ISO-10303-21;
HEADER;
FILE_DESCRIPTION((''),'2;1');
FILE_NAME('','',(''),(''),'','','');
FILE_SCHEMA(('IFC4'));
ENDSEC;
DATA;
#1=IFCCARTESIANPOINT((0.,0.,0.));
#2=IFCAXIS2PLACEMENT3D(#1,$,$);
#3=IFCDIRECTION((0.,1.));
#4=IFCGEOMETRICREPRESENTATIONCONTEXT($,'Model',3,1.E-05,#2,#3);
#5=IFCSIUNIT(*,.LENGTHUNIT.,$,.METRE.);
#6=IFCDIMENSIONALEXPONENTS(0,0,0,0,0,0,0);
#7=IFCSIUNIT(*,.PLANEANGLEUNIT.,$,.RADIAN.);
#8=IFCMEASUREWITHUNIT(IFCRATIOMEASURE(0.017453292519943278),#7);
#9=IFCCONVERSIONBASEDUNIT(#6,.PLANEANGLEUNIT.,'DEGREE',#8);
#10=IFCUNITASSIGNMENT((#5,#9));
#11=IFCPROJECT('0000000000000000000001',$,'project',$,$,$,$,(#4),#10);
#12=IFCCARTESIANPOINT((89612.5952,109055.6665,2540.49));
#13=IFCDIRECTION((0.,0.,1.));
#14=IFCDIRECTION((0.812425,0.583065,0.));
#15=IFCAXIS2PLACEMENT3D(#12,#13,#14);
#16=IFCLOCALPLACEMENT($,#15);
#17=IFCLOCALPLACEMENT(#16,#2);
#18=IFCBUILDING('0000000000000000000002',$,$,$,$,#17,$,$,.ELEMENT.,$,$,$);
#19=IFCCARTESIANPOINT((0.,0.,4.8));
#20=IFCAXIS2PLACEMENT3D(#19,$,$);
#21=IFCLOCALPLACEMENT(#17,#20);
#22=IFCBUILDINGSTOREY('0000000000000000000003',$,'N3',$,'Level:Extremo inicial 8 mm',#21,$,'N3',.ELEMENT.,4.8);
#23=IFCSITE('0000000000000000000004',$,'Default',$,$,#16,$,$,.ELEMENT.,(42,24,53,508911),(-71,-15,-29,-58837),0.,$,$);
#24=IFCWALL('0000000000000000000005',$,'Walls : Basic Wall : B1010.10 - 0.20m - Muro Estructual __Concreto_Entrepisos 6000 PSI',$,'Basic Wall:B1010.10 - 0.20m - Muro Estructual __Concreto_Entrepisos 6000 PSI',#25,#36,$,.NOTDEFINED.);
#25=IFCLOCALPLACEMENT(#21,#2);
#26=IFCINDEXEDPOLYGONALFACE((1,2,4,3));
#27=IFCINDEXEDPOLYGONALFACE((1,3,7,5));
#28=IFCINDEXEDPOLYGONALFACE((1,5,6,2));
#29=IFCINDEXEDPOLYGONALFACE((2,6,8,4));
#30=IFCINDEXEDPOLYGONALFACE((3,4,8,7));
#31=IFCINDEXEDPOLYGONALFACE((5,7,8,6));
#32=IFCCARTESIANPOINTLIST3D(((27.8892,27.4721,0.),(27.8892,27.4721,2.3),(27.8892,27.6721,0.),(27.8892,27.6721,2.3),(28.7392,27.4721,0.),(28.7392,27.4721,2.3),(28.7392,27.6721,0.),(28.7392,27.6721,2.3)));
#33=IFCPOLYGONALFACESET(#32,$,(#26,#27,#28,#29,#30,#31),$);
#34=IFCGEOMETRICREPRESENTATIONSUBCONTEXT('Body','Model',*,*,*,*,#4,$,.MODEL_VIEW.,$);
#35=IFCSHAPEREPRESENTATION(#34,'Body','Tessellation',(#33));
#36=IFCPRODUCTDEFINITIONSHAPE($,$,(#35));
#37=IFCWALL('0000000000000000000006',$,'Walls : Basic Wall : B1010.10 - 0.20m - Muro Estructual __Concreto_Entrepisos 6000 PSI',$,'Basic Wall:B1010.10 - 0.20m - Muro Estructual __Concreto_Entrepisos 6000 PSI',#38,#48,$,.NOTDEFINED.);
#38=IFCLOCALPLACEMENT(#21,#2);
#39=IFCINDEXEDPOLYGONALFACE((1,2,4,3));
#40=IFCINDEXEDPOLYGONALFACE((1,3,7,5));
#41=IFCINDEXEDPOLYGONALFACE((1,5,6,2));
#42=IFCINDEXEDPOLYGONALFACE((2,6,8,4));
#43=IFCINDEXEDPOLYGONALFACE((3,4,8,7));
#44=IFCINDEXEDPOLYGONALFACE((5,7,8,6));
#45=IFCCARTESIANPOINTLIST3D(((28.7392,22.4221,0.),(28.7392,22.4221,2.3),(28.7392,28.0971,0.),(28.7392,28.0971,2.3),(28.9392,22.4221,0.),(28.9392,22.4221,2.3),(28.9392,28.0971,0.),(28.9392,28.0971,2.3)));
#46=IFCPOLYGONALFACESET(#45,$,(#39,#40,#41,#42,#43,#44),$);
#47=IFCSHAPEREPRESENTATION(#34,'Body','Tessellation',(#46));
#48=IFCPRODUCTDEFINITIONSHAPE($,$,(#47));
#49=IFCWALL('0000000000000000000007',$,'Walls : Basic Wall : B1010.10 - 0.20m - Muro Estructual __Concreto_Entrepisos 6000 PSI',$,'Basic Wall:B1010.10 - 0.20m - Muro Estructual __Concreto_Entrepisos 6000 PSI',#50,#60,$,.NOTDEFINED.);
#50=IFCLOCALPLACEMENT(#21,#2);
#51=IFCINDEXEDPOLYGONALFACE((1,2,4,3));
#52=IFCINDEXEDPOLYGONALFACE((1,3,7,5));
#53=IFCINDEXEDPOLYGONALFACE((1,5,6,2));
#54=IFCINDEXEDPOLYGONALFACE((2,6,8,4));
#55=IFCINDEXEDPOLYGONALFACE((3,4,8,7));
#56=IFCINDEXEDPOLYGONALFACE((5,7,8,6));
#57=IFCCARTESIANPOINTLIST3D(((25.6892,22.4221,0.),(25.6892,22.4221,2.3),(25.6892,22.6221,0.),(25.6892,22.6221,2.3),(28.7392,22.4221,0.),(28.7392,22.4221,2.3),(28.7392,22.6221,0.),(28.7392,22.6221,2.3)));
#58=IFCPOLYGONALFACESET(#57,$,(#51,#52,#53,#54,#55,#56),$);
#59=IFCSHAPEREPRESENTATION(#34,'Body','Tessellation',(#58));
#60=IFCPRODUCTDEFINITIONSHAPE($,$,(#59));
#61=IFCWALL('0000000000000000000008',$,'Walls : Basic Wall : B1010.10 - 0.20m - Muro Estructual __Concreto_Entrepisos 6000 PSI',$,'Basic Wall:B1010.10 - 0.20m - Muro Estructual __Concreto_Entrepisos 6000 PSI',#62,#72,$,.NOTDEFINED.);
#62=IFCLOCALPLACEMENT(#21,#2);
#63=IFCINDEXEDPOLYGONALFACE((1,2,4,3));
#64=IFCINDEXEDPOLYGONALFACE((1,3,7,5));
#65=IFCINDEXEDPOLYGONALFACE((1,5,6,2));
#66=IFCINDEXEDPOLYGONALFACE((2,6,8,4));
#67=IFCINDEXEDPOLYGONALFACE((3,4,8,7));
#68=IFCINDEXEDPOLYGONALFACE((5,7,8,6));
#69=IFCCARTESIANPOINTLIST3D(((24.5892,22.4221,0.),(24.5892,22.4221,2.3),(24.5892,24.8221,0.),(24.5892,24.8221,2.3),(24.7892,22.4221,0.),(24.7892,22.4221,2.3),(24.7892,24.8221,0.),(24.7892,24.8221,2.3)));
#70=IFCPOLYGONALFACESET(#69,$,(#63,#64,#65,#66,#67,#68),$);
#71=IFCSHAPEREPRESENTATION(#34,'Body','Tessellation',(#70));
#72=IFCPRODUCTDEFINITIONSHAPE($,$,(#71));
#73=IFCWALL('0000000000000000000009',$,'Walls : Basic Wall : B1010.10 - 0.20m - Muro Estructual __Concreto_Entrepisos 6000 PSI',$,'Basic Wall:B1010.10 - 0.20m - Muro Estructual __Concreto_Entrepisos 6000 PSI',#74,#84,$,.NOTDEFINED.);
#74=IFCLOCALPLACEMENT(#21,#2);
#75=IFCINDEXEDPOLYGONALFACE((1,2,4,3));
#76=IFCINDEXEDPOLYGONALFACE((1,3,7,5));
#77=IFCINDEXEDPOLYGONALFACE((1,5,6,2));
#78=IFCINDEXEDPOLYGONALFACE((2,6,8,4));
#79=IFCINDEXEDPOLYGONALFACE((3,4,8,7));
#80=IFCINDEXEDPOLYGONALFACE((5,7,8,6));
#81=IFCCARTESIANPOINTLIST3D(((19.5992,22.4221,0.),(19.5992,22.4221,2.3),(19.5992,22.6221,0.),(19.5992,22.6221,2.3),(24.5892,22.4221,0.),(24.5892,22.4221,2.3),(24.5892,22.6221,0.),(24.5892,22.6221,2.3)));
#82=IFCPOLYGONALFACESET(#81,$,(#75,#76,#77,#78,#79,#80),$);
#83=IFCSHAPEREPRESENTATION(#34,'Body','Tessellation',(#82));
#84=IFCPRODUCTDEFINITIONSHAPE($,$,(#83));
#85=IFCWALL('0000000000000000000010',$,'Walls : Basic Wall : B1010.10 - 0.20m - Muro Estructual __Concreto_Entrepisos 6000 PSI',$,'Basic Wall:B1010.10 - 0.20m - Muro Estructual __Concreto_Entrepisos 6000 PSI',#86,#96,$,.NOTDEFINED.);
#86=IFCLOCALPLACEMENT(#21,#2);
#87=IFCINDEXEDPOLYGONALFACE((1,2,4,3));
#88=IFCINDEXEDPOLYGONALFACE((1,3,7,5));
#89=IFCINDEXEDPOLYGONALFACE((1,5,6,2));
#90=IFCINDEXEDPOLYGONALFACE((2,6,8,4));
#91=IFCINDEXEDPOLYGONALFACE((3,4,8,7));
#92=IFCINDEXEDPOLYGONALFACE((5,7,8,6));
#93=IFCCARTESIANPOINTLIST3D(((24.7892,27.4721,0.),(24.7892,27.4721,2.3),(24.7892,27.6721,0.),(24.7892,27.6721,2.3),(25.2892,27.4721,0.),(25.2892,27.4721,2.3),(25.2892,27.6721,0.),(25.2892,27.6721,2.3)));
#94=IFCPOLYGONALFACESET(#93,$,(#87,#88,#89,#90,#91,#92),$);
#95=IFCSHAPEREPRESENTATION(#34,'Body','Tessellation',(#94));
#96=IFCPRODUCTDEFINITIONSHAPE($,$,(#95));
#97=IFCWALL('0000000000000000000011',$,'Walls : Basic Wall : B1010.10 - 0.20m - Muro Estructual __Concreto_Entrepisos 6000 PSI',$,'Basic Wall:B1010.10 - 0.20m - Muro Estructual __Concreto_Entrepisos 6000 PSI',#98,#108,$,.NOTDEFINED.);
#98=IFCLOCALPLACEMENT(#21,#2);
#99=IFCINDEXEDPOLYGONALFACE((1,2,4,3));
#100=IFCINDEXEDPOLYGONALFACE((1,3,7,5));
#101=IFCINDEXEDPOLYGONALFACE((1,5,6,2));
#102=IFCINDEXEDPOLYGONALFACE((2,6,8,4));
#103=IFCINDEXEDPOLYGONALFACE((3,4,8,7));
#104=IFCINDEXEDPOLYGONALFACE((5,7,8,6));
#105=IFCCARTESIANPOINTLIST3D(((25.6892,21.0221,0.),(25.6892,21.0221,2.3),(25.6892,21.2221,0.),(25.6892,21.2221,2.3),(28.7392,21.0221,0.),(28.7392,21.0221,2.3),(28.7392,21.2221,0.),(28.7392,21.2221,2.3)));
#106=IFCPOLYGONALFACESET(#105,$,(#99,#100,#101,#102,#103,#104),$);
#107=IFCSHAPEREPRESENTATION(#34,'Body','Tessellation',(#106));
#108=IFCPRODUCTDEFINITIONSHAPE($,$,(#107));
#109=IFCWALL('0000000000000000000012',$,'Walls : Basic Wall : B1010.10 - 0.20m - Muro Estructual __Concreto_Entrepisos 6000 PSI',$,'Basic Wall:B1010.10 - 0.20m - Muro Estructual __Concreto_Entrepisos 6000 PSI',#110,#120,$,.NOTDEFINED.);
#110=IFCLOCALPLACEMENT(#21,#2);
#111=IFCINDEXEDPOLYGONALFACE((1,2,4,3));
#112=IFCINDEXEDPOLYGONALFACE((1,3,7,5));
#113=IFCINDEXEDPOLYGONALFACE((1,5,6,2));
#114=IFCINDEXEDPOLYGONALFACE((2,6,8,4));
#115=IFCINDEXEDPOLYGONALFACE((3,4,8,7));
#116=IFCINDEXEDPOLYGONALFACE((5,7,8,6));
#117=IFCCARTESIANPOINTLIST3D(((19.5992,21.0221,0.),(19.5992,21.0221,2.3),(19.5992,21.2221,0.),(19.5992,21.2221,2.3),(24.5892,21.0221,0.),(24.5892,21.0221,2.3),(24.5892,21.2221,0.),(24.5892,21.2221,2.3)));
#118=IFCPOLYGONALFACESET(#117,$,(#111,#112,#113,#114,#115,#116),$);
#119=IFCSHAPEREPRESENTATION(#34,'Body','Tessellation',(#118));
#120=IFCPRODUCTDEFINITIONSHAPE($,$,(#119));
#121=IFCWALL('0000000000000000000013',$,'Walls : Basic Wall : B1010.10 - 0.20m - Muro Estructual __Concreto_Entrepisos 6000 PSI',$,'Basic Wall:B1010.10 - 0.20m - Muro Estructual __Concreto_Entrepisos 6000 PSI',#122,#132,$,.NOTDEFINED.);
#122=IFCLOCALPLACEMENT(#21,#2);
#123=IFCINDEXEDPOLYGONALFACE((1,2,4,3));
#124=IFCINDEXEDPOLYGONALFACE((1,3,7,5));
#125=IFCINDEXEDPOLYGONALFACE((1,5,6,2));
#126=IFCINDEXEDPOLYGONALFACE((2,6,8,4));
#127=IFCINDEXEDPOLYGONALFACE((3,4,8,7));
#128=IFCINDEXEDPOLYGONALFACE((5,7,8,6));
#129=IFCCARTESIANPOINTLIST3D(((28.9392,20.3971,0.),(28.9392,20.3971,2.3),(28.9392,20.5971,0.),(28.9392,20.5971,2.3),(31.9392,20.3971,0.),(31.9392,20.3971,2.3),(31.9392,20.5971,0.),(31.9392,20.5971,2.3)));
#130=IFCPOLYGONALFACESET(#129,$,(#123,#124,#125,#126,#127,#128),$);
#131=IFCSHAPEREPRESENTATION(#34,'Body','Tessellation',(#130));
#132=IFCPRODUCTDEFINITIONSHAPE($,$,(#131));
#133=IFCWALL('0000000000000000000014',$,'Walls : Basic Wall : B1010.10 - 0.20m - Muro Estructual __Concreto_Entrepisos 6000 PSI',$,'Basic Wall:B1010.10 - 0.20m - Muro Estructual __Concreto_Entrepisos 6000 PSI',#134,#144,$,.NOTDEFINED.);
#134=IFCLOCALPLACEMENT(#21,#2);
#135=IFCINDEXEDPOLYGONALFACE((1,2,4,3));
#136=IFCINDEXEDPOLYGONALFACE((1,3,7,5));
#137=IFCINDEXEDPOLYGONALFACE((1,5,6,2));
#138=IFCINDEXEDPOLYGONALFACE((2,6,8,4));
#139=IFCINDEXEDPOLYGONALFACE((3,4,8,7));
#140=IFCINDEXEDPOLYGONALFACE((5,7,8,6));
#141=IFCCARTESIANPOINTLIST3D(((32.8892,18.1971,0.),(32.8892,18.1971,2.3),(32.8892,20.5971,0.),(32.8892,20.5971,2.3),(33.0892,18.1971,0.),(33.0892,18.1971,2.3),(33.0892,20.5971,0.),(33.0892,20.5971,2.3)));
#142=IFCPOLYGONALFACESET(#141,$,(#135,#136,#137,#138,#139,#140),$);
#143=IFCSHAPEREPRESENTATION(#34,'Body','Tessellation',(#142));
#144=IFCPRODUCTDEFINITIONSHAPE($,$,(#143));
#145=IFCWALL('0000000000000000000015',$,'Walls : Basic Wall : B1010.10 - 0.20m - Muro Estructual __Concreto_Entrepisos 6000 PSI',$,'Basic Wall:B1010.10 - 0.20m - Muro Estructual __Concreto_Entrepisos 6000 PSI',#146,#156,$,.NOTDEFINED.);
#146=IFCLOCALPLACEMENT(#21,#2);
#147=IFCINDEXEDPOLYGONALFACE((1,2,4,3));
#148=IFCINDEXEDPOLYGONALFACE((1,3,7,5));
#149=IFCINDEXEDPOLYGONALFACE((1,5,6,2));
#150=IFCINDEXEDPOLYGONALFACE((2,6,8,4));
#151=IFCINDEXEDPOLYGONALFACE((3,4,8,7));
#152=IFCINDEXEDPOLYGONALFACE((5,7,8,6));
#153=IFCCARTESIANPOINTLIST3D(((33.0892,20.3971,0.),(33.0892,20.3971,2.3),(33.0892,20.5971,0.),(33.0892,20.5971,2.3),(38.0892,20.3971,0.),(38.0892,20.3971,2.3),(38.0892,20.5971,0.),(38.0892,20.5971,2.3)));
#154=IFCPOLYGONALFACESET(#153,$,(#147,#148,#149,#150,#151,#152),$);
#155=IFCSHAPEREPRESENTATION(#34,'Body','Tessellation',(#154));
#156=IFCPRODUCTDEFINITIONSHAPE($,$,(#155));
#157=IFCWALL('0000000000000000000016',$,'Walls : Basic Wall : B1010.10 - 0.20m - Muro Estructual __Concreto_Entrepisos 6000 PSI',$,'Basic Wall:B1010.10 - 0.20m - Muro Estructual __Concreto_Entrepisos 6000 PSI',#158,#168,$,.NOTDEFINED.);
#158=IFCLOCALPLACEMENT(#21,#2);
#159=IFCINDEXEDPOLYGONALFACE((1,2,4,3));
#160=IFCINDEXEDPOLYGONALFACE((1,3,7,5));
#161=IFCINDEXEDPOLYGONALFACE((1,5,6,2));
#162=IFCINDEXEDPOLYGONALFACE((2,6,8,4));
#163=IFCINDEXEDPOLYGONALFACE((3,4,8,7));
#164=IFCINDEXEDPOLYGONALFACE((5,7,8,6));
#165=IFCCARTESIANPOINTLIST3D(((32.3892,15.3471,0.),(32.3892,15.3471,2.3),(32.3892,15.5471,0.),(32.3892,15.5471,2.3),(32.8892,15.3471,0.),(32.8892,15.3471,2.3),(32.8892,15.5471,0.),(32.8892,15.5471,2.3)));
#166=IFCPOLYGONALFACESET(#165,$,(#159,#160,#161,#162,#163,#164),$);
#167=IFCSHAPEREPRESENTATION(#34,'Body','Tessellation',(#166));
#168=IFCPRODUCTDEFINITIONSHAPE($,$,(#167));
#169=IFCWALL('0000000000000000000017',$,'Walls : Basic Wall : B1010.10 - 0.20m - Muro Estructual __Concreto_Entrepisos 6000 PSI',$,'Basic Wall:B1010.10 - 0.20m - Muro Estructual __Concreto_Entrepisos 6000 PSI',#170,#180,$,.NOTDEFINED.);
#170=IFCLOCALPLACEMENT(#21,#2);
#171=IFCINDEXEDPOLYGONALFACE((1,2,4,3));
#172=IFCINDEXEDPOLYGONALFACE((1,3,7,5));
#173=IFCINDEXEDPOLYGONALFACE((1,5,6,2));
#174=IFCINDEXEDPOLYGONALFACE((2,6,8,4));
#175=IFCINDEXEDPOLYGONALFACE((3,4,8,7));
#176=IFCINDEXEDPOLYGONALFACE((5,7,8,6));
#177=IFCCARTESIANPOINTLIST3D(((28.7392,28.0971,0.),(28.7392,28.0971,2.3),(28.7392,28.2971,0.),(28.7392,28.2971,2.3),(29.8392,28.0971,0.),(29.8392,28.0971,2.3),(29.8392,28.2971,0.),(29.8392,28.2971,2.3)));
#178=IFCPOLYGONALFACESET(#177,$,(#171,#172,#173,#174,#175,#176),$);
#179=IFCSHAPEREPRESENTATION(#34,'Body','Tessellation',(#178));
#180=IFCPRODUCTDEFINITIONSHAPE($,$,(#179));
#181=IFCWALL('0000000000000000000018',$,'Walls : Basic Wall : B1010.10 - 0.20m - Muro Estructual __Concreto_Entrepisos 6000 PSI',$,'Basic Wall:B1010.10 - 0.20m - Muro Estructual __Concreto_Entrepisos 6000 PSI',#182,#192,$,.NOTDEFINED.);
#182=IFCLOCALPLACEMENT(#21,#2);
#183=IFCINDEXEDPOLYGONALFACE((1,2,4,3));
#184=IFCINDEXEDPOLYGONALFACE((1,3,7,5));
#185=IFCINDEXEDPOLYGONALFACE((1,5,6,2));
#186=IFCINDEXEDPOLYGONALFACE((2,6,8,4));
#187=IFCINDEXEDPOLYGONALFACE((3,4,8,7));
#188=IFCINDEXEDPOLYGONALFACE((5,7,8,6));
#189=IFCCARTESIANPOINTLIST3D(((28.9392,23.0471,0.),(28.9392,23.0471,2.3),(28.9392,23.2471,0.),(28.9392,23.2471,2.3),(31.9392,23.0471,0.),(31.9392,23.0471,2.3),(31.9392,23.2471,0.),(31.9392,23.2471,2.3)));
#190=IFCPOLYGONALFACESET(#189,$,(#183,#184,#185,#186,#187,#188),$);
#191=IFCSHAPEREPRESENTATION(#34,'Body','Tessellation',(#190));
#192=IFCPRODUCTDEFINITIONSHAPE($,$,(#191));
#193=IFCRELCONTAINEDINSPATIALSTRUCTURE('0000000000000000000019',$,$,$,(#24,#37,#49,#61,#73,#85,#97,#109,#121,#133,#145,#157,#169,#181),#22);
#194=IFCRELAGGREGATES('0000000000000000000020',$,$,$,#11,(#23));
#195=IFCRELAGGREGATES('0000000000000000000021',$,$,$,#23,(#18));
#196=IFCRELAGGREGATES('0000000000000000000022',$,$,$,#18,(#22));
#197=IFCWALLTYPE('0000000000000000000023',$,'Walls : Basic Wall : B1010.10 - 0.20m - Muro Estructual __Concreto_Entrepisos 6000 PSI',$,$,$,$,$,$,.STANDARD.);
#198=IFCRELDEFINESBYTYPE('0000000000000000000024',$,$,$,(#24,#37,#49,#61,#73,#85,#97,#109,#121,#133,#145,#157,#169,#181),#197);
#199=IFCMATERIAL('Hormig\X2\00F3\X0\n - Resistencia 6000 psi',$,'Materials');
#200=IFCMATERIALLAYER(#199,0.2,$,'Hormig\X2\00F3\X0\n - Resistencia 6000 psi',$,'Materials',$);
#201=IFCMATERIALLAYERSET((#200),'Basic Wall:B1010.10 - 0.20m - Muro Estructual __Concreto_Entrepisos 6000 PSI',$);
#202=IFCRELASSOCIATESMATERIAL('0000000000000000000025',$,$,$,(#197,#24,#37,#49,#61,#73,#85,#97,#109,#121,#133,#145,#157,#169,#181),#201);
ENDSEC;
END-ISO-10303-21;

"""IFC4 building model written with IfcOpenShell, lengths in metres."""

from ifc_helpers import new_model, entity, si_unit, converted_unit, direction, frame, frame_2d, origin, place, context, subcontext, project, spatial, rectangle, extrude, material, layer, layer_set, layer_usage, type_object, element, save


model = new_model("IFC4")

# Units and contexts
model_context = context("Model", 3, precision=1e-05, world=origin(), true_north=direction((0.0, 1.0)))
body_context = subcontext(model_context, "Body", "Model", "MODEL_VIEW")
ifc_project = project(units=[si_unit("LENGTHUNIT", "METRE"), converted_unit("PLANEANGLEUNIT", "DEGREE", entity("IfcRatioMeasure", 0.017453292519943278), si_unit("PLANEANGLEUNIT", "RADIAN"), dimensions=[0, 0, 0, 0, 0, 0, 0])], contexts=[model_context])

# Site, building, storey
site_placement = place(None, frame((89612.5952, 109055.6665, 2540.49), z_axis=(0.0, 0.0, 1.0), x_axis=(0.812425, 0.583065, 0.0)))
site = spatial("IfcSite", under=ifc_project, at=site_placement, Name="Default", CompositionType="ELEMENT", RefLatitude=(42, 24, 53, 508911), RefLongitude=(-71, -15, -29, -58837), RefElevation=0.0)
building_placement = place(site_placement, origin())
building = spatial("IfcBuilding", under=site, at=building_placement, CompositionType="ELEMENT")
storey_placement = place(building_placement, frame((0.0, 0.0, 4.8)))
storey = spatial("IfcBuildingStorey", under=building, at=storey_placement, Name="N3", ObjectType="Level:Extremo inicial 8 mm", LongName="N3", CompositionType="ELEMENT", Elevation=4.8)

# Walls
ifc_material = material(Name="Hormigón - Resistencia 6000 psi", Category="Materials")
ifc_layer_1 = layer(ifc_material, 0.2, Name="Hormigón - Resistencia 6000 psi", Category="Materials")
ifc_layer_set_1 = layer_set([ifc_layer_1], Name="Basic Wall:B1010.10 - 0.20m - Muro Estructual __Concreto_Entrepisos 6000 PSI")
ifc_layer_usage_1 = layer_usage(ifc_layer_set_1, "AXIS2", "NEGATIVE", 0.1)
wall_type_1 = type_object("IfcWallType", Name="Walls : Basic Wall : B1010.10 - 0.20m - Muro Estructual __Concreto_Entrepisos 6000 PSI", PredefinedType="STANDARD", material=ifc_layer_set_1)
wall_1_placement = place(storey_placement, frame((27.8892, 27.5721, 0.0)))
element("IfcWall", 1, at=wall_1_placement, inside=storey, type_object=wall_type_1, material=ifc_layer_usage_1, Name="Walls : Basic Wall : B1010.10 - 0.20m - Muro Estructual __Concreto_Entrepisos 6000 PSI", ObjectType="Basic Wall:B1010.10 - 0.20m - Muro Estructual __Concreto_Entrepisos 6000 PSI", PredefinedType="NOTDEFINED", context=body_context, shape_type="SweptSolid", body=[
    extrude(rectangle(XDim=0.85, YDim=0.2, at=frame_2d((0.425, 0.0), x_axis=(-1.0, 0.0))), origin(), (0.0, 0.0, 1.0), 2.3),
])
ifc_layer_usage_2 = layer_usage(ifc_layer_set_1, "AXIS2", "NEGATIVE", 0.1)
wall_2_placement = place(storey_placement, frame((28.8392, 28.0971, 0.0), z_axis=(0.0, 0.0, 1.0), x_axis=(0.0, -1.0, 0.0)))
element("IfcWall", 2, at=wall_2_placement, inside=storey, type_object=wall_type_1, material=ifc_layer_usage_2, Name="Walls : Basic Wall : B1010.10 - 0.20m - Muro Estructual __Concreto_Entrepisos 6000 PSI", ObjectType="Basic Wall:B1010.10 - 0.20m - Muro Estructual __Concreto_Entrepisos 6000 PSI", PredefinedType="NOTDEFINED", context=body_context, shape_type="SweptSolid", body=[
    extrude(rectangle(XDim=5.675, YDim=0.2, at=frame_2d((2.8375, 0.0), x_axis=(-1.0, 0.0))), origin(), (0.0, 0.0, 1.0), 2.3),
])
ifc_layer_usage_3 = layer_usage(ifc_layer_set_1, "AXIS2", "NEGATIVE", 0.1)
wall_3_placement = place(storey_placement, frame((28.7392, 22.5221, 0.0), z_axis=(0.0, 0.0, 1.0), x_axis=(-1.0, 0.0, 0.0)))
element("IfcWall", 3, at=wall_3_placement, inside=storey, type_object=wall_type_1, material=ifc_layer_usage_3, Name="Walls : Basic Wall : B1010.10 - 0.20m - Muro Estructual __Concreto_Entrepisos 6000 PSI", ObjectType="Basic Wall:B1010.10 - 0.20m - Muro Estructual __Concreto_Entrepisos 6000 PSI", PredefinedType="NOTDEFINED", context=body_context, shape_type="SweptSolid", body=[
    extrude(rectangle(XDim=3.05, YDim=0.2, at=frame_2d((1.525, 0.0), x_axis=(-1.0, 0.0))), origin(), (0.0, 0.0, 1.0), 2.3),
])
ifc_layer_usage_4 = layer_usage(ifc_layer_set_1, "AXIS2", "NEGATIVE", 0.1)
wall_4_placement = place(storey_placement, frame((24.6892, 24.8221, 0.0), z_axis=(0.0, 0.0, 1.0), x_axis=(0.0, -1.0, 0.0)))
element("IfcWall", 4, at=wall_4_placement, inside=storey, type_object=wall_type_1, material=ifc_layer_usage_4, Name="Walls : Basic Wall : B1010.10 - 0.20m - Muro Estructual __Concreto_Entrepisos 6000 PSI", ObjectType="Basic Wall:B1010.10 - 0.20m - Muro Estructual __Concreto_Entrepisos 6000 PSI", PredefinedType="NOTDEFINED", context=body_context, shape_type="SweptSolid", body=[
    extrude(rectangle(XDim=2.4, YDim=0.2, at=frame_2d((1.2, 0.0), x_axis=(-1.0, 0.0))), origin(), (0.0, 0.0, 1.0), 2.3),
])
ifc_layer_usage_5 = layer_usage(ifc_layer_set_1, "AXIS2", "NEGATIVE", 0.1)
wall_5_placement = place(storey_placement, frame((24.5892, 22.5221, 0.0), z_axis=(0.0, 0.0, 1.0), x_axis=(-1.0, 0.0, 0.0)))
element("IfcWall", 5, at=wall_5_placement, inside=storey, type_object=wall_type_1, material=ifc_layer_usage_5, Name="Walls : Basic Wall : B1010.10 - 0.20m - Muro Estructual __Concreto_Entrepisos 6000 PSI", ObjectType="Basic Wall:B1010.10 - 0.20m - Muro Estructual __Concreto_Entrepisos 6000 PSI", PredefinedType="NOTDEFINED", context=body_context, shape_type="SweptSolid", body=[
    extrude(rectangle(XDim=4.99, YDim=0.2, at=frame_2d((2.495, 0.0), x_axis=(-1.0, 0.0))), origin(), (0.0, 0.0, 1.0), 2.3),
])
ifc_layer_usage_6 = layer_usage(ifc_layer_set_1, "AXIS2", "NEGATIVE", 0.1)
wall_6_placement = place(storey_placement, frame((25.2892, 27.5721, 0.0), z_axis=(0.0, 0.0, 1.0), x_axis=(-1.0, 0.0, 0.0)))
element("IfcWall", 6, at=wall_6_placement, inside=storey, type_object=wall_type_1, material=ifc_layer_usage_6, Name="Walls : Basic Wall : B1010.10 - 0.20m - Muro Estructual __Concreto_Entrepisos 6000 PSI", ObjectType="Basic Wall:B1010.10 - 0.20m - Muro Estructual __Concreto_Entrepisos 6000 PSI", PredefinedType="NOTDEFINED", context=body_context, shape_type="SweptSolid", body=[
    extrude(rectangle(XDim=0.5, YDim=0.2, at=frame_2d((0.25, 0.0), x_axis=(-1.0, 0.0))), origin(), (0.0, 0.0, 1.0), 2.3),
])
ifc_layer_usage_7 = layer_usage(ifc_layer_set_1, "AXIS2", "POSITIVE", -0.1)
wall_7_placement = place(storey_placement, frame((28.7392, 21.1221, 0.0), z_axis=(0.0, 0.0, 1.0), x_axis=(-1.0, 0.0, 0.0)))
element("IfcWall", 7, at=wall_7_placement, inside=storey, type_object=wall_type_1, material=ifc_layer_usage_7, Name="Walls : Basic Wall : B1010.10 - 0.20m - Muro Estructual __Concreto_Entrepisos 6000 PSI", ObjectType="Basic Wall:B1010.10 - 0.20m - Muro Estructual __Concreto_Entrepisos 6000 PSI", PredefinedType="NOTDEFINED", context=body_context, shape_type="SweptSolid", body=[
    extrude(rectangle(XDim=3.05, YDim=0.2, at=frame_2d((1.525, 0.0), x_axis=(-1.0, 0.0))), origin(), (0.0, 0.0, 1.0), 2.3),
])
ifc_layer_usage_8 = layer_usage(ifc_layer_set_1, "AXIS2", "POSITIVE", -0.1)
wall_8_placement = place(storey_placement, frame((24.5892, 21.1221, 0.0), z_axis=(0.0, 0.0, 1.0), x_axis=(-1.0, 0.0, 0.0)))
element("IfcWall", 8, at=wall_8_placement, inside=storey, type_object=wall_type_1, material=ifc_layer_usage_8, Name="Walls : Basic Wall : B1010.10 - 0.20m - Muro Estructual __Concreto_Entrepisos 6000 PSI", ObjectType="Basic Wall:B1010.10 - 0.20m - Muro Estructual __Concreto_Entrepisos 6000 PSI", PredefinedType="NOTDEFINED", context=body_context, shape_type="SweptSolid", body=[
    extrude(rectangle(XDim=4.99, YDim=0.2, at=frame_2d((2.495, 0.0), x_axis=(-1.0, 0.0))), origin(), (0.0, 0.0, 1.0), 2.3),
])
ifc_layer_usage_9 = layer_usage(ifc_layer_set_1, "AXIS2", "NEGATIVE", 0.1)
wall_9_placement = place(storey_placement, frame((28.9392, 20.4971, 0.0)))
element("IfcWall", 9, at=wall_9_placement, inside=storey, type_object=wall_type_1, material=ifc_layer_usage_9, Name="Walls : Basic Wall : B1010.10 - 0.20m - Muro Estructual __Concreto_Entrepisos 6000 PSI", ObjectType="Basic Wall:B1010.10 - 0.20m - Muro Estructual __Concreto_Entrepisos 6000 PSI", PredefinedType="NOTDEFINED", context=body_context, shape_type="SweptSolid", body=[
    extrude(rectangle(XDim=3.0, YDim=0.2, at=frame_2d((1.5, 0.0), x_axis=(-1.0, 0.0))), origin(), (0.0, 0.0, 1.0), 2.3),
])
ifc_layer_usage_10 = layer_usage(ifc_layer_set_1, "AXIS2", "NEGATIVE", 0.1)
wall_10_placement = place(storey_placement, frame((32.9892, 18.1971, 0.0), z_axis=(0.0, 0.0, 1.0), x_axis=(0.0, 1.0, 0.0)))
element("IfcWall", 10, at=wall_10_placement, inside=storey, type_object=wall_type_1, material=ifc_layer_usage_10, Name="Walls : Basic Wall : B1010.10 - 0.20m - Muro Estructual __Concreto_Entrepisos 6000 PSI", ObjectType="Basic Wall:B1010.10 - 0.20m - Muro Estructual __Concreto_Entrepisos 6000 PSI", PredefinedType="NOTDEFINED", context=body_context, shape_type="SweptSolid", body=[
    extrude(rectangle(XDim=2.4, YDim=0.2, at=frame_2d((1.2, 0.0), x_axis=(-1.0, 0.0))), origin(), (0.0, 0.0, 1.0), 2.3),
])
ifc_layer_usage_11 = layer_usage(ifc_layer_set_1, "AXIS2", "NEGATIVE", 0.1)
wall_11_placement = place(storey_placement, frame((33.0892, 20.4971, 0.0)))
element("IfcWall", 11, at=wall_11_placement, inside=storey, type_object=wall_type_1, material=ifc_layer_usage_11, Name="Walls : Basic Wall : B1010.10 - 0.20m - Muro Estructual __Concreto_Entrepisos 6000 PSI", ObjectType="Basic Wall:B1010.10 - 0.20m - Muro Estructual __Concreto_Entrepisos 6000 PSI", PredefinedType="NOTDEFINED", context=body_context, shape_type="SweptSolid", body=[
    extrude(rectangle(XDim=5.0, YDim=0.2, at=frame_2d((2.5, 0.0), x_axis=(-1.0, 0.0))), origin(), (0.0, 0.0, 1.0), 2.3),
])
ifc_layer_usage_12 = layer_usage(ifc_layer_set_1, "AXIS2", "NEGATIVE", 0.1)
wall_12_placement = place(storey_placement, frame((32.3892, 15.4471, 0.0)))
element("IfcWall", 12, at=wall_12_placement, inside=storey, type_object=wall_type_1, material=ifc_layer_usage_12, Name="Walls : Basic Wall : B1010.10 - 0.20m - Muro Estructual __Concreto_Entrepisos 6000 PSI", ObjectType="Basic Wall:B1010.10 - 0.20m - Muro Estructual __Concreto_Entrepisos 6000 PSI", PredefinedType="NOTDEFINED", context=body_context, shape_type="SweptSolid", body=[
    extrude(rectangle(XDim=0.5, YDim=0.2, at=frame_2d((0.25, 0.0), x_axis=(-1.0, 0.0))), origin(), (0.0, 0.0, 1.0), 2.3),
])
ifc_layer_usage_13 = layer_usage(ifc_layer_set_1, "AXIS2", "POSITIVE", -0.1)
wall_13_placement = place(storey_placement, frame((29.8392, 28.1971, 0.0), z_axis=(0.0, 0.0, 1.0), x_axis=(-1.0, 0.0, 0.0)))
element("IfcWall", 13, at=wall_13_placement, inside=storey, type_object=wall_type_1, material=ifc_layer_usage_13, Name="Walls : Basic Wall : B1010.10 - 0.20m - Muro Estructual __Concreto_Entrepisos 6000 PSI", ObjectType="Basic Wall:B1010.10 - 0.20m - Muro Estructual __Concreto_Entrepisos 6000 PSI", PredefinedType="NOTDEFINED", context=body_context, shape_type="SweptSolid", body=[
    extrude(rectangle(XDim=1.1, YDim=0.2, at=frame_2d((0.55, 0.0), x_axis=(-1.0, 0.0))), origin(), (0.0, 0.0, 1.0), 2.3),
])
ifc_layer_usage_14 = layer_usage(ifc_layer_set_1, "AXIS2", "POSITIVE", -0.1)
wall_14_placement = place(storey_placement, frame((28.9392, 23.1471, 0.0)))
element("IfcWall", 14, at=wall_14_placement, inside=storey, type_object=wall_type_1, material=ifc_layer_usage_14, Name="Walls : Basic Wall : B1010.10 - 0.20m - Muro Estructual __Concreto_Entrepisos 6000 PSI", ObjectType="Basic Wall:B1010.10 - 0.20m - Muro Estructual __Concreto_Entrepisos 6000 PSI", PredefinedType="NOTDEFINED", context=body_context, shape_type="SweptSolid", body=[
    extrude(rectangle(XDim=3.0, YDim=0.2, at=frame_2d((1.5, 0.0), x_axis=(-1.0, 0.0))), origin(), (0.0, 0.0, 1.0), 2.3),
])

save(model, "model.ifc")
